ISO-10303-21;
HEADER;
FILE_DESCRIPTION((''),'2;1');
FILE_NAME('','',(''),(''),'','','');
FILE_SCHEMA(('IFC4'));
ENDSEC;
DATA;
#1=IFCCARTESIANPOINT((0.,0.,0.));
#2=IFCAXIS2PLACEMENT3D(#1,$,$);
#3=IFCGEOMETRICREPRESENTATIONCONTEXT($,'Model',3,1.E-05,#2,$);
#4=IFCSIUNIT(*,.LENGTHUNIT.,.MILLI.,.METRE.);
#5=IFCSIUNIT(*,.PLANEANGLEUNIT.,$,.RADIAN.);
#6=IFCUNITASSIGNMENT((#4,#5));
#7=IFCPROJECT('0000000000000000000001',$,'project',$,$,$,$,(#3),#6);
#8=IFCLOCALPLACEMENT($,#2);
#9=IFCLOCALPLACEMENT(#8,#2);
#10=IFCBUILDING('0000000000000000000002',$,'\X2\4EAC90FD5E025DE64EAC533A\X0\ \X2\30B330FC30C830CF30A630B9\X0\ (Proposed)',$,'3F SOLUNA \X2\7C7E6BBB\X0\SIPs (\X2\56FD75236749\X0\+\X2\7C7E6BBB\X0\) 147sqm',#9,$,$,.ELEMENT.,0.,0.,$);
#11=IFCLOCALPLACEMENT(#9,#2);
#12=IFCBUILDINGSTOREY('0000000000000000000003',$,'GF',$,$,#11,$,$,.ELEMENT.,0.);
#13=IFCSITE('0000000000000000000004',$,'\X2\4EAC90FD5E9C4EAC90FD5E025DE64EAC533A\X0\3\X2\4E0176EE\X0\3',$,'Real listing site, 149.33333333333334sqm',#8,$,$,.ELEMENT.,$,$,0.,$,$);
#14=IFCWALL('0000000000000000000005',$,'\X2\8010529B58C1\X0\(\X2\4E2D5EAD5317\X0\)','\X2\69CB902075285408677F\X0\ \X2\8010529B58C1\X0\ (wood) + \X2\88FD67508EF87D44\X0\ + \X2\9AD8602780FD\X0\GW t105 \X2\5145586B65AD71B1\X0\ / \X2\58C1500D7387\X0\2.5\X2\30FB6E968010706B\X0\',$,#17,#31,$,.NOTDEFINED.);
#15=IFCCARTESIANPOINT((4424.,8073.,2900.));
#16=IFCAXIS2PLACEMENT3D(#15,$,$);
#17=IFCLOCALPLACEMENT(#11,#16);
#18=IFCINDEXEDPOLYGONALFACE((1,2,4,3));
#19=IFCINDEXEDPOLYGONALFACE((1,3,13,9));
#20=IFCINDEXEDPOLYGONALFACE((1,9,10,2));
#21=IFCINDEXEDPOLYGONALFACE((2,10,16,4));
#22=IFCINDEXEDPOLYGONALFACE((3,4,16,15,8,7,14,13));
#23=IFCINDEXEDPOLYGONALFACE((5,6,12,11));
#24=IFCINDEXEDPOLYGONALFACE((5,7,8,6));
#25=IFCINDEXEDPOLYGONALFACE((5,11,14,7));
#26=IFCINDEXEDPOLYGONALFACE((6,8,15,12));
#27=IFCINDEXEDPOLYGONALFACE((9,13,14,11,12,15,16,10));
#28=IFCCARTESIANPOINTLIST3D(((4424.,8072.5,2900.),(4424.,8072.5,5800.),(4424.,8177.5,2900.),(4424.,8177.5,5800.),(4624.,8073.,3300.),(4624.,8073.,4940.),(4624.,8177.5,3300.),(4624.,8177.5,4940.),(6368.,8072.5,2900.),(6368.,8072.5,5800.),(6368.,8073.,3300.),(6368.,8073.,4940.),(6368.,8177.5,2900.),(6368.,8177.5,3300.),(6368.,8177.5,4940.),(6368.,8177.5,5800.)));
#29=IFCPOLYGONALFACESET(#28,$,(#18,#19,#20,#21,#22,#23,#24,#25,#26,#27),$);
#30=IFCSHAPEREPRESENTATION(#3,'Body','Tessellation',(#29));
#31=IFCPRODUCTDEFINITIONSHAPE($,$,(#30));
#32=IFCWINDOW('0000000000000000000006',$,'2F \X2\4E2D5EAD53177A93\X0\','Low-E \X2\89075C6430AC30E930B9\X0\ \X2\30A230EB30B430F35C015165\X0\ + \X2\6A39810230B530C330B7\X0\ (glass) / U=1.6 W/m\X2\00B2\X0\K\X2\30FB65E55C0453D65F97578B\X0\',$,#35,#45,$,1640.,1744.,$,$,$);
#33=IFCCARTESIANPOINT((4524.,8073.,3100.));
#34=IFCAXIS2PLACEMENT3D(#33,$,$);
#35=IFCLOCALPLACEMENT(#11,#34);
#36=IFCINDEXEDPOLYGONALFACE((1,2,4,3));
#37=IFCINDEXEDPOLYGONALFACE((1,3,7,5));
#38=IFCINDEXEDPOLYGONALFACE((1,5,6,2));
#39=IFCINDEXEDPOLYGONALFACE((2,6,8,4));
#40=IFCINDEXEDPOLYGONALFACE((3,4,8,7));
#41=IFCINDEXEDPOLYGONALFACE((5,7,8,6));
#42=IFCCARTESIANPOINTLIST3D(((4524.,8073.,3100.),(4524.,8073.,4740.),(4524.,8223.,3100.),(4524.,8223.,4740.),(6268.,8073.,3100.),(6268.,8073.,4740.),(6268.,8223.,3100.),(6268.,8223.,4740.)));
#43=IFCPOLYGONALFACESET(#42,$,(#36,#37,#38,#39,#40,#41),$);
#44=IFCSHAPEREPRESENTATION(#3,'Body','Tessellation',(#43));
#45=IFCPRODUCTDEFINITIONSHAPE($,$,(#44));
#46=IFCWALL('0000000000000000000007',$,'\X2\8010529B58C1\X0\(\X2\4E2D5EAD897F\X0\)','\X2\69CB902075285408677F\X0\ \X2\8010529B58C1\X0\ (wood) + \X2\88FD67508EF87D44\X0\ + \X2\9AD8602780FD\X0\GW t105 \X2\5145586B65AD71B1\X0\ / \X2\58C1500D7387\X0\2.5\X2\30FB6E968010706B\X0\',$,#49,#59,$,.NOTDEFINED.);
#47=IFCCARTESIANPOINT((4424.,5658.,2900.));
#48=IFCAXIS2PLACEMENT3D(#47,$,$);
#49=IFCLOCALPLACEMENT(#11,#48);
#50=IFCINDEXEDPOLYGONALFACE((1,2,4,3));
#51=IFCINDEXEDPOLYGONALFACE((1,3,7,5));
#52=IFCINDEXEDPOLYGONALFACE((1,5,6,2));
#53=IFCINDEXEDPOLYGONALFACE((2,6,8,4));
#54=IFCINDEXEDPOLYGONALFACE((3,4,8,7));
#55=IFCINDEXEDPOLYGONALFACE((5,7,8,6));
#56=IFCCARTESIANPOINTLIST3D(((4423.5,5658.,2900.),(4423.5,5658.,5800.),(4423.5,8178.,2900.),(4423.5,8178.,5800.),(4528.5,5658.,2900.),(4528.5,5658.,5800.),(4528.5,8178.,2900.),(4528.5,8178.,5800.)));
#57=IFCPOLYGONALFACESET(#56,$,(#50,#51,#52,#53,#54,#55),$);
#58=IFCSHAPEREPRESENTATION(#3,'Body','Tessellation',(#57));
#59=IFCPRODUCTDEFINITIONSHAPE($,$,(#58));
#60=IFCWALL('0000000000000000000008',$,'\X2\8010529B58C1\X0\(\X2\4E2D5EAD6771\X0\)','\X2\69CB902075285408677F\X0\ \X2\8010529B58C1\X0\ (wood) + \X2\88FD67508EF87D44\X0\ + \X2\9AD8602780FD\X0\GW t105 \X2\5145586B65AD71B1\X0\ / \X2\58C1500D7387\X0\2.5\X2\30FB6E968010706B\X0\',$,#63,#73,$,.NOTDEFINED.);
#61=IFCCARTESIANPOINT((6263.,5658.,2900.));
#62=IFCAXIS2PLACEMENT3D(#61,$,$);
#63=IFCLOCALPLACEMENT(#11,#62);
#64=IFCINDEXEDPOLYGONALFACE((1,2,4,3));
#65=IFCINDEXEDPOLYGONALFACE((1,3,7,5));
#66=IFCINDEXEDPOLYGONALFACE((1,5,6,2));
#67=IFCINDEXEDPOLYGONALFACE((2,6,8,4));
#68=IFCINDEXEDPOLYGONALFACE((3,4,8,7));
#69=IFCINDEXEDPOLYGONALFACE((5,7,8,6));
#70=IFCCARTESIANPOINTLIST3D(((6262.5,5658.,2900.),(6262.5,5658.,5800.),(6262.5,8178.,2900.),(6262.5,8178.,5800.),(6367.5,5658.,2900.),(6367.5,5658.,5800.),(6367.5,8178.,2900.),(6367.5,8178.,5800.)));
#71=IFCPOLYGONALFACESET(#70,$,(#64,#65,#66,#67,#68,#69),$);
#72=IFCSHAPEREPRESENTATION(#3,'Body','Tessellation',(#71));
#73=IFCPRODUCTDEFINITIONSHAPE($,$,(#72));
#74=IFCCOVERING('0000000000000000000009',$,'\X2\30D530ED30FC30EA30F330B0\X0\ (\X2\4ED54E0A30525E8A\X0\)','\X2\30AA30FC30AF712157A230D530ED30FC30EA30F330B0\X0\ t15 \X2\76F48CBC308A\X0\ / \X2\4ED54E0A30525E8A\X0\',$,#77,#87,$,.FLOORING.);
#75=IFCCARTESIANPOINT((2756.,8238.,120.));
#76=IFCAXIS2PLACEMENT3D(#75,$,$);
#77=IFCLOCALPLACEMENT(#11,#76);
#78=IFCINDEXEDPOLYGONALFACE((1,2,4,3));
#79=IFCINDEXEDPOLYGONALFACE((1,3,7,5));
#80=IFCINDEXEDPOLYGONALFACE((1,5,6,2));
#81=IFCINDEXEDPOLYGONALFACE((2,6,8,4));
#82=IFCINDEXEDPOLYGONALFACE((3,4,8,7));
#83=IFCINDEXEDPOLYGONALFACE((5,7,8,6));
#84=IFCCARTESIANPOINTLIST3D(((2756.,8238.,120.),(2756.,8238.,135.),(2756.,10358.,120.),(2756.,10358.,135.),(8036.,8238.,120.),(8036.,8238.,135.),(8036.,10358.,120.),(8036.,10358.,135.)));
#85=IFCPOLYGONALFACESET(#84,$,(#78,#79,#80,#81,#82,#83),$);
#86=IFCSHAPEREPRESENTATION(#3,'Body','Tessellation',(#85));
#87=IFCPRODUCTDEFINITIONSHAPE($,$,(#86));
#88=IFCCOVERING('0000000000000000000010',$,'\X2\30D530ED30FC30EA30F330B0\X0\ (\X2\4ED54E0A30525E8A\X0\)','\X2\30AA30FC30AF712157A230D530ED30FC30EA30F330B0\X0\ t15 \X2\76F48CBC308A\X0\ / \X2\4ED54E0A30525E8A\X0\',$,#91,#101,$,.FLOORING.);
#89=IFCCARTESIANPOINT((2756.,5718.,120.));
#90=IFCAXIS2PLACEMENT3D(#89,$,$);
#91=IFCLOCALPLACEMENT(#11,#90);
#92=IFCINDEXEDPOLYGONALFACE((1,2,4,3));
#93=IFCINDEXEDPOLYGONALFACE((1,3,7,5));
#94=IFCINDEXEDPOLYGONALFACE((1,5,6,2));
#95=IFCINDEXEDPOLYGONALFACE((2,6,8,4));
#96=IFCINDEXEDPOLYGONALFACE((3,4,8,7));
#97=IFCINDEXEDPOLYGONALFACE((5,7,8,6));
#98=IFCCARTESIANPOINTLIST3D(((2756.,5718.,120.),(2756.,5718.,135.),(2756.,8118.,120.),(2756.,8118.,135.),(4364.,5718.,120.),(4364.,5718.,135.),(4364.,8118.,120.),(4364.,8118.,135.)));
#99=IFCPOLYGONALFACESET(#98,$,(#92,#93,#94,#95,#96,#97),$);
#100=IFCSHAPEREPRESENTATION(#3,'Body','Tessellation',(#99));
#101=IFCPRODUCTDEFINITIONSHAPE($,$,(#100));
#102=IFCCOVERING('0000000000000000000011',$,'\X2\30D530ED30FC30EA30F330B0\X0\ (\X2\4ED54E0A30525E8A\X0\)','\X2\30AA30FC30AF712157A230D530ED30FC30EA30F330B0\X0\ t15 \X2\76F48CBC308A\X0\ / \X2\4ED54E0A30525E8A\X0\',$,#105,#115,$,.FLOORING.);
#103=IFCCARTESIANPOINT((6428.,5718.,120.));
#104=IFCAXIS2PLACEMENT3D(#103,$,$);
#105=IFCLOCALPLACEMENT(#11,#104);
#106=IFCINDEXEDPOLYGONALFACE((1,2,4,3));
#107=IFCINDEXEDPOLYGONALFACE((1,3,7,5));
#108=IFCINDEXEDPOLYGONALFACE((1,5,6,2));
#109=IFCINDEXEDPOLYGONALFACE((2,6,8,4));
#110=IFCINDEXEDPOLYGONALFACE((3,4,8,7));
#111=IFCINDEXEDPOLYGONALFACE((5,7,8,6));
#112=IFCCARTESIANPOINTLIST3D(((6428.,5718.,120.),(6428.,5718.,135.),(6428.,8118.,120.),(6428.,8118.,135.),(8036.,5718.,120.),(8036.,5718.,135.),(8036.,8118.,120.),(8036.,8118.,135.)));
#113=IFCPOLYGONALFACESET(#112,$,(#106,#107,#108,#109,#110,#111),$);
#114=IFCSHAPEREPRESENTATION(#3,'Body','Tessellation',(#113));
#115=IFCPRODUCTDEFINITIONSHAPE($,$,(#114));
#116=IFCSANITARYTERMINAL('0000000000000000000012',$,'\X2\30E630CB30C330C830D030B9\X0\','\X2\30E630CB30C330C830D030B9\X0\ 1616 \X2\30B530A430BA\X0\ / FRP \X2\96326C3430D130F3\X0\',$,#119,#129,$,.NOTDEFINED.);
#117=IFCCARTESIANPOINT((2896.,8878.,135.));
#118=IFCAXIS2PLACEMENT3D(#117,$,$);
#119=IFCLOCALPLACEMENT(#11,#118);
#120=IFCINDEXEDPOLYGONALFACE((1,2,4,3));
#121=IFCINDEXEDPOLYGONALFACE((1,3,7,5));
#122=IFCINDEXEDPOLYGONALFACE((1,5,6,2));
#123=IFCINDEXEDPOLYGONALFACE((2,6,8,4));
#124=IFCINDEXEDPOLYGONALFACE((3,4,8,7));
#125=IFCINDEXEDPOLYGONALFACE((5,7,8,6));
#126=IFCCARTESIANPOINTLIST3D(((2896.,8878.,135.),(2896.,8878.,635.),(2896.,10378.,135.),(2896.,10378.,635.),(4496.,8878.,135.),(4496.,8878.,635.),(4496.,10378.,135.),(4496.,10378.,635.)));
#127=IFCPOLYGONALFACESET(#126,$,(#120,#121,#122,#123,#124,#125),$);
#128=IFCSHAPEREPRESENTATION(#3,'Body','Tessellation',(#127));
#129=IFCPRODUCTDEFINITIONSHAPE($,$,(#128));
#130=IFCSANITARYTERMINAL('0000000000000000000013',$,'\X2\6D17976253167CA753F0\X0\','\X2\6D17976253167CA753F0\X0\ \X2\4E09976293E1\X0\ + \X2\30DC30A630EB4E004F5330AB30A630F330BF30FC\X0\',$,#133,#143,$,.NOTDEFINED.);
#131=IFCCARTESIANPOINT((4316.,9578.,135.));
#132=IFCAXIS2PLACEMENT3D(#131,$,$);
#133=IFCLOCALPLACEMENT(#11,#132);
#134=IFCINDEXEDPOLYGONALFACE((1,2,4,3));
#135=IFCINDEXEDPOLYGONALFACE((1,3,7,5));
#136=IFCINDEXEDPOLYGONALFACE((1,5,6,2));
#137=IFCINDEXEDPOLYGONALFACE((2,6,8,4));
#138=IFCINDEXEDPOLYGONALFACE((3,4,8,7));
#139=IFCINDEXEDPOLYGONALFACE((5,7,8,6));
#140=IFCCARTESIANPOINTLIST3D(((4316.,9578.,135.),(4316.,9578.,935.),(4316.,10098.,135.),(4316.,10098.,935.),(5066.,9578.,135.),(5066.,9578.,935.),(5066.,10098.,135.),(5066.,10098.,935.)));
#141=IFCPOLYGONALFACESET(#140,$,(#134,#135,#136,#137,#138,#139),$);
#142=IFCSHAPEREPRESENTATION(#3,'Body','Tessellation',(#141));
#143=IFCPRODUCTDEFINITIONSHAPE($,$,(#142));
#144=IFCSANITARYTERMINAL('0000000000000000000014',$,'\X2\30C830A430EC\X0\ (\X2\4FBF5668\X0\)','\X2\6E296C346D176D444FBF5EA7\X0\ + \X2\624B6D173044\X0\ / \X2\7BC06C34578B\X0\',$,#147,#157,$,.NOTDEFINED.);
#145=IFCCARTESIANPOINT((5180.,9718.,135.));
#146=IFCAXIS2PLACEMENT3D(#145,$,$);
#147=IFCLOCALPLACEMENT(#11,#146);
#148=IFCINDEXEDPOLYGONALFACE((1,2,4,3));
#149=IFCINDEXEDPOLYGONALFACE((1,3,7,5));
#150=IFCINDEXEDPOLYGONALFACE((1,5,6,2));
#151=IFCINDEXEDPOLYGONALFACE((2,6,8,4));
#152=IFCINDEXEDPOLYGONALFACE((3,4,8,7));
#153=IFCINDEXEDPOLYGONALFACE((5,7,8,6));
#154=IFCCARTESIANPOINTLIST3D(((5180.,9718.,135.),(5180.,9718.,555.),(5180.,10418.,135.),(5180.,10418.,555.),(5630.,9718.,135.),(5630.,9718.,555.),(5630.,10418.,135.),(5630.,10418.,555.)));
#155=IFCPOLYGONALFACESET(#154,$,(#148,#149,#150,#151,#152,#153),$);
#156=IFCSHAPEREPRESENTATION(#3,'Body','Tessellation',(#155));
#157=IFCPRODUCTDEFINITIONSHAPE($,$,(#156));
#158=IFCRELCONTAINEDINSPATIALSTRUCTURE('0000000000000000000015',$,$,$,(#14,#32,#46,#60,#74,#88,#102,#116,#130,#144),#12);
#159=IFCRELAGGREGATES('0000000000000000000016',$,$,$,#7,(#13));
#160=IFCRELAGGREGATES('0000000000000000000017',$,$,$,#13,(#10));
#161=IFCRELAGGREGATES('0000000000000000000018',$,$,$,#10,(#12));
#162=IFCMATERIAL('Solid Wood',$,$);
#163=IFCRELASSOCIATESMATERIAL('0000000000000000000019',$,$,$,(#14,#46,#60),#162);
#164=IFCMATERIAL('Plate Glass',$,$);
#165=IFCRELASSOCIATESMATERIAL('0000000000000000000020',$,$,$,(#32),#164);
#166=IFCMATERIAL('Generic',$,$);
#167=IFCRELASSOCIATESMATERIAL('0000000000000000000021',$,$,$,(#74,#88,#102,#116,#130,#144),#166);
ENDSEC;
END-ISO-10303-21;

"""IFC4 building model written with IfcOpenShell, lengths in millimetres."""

from ifc_helpers import new_model, si_unit, frame, frame_2d, origin, place, context, project, spatial, rectangle, extrude, material, element, fill, save


model = new_model("IFC4")

# Units and contexts
model_context = context("Model", 3, precision=1e-05, world=origin())
ifc_project = project(units=[si_unit("LENGTHUNIT", "METRE", prefix="MILLI"), si_unit("PLANEANGLEUNIT", "RADIAN")], contexts=[model_context])

# Site, building, storey
site_placement = place(None, origin())
site = spatial("IfcSite", under=ifc_project, at=site_placement, Name="京都府京都市左京区3丁目3", ObjectType="Real listing site, 149.33333333333334sqm", CompositionType="ELEMENT", RefElevation=0.0)
building_placement = place(site_placement, origin())
building = spatial("IfcBuilding", under=site, at=building_placement, Name="京都市左京区 コートハウス (Proposed)", ObjectType="3F SOLUNA 籾殻SIPs (国産杉+籾殻) 147sqm", CompositionType="ELEMENT", ElevationOfRefHeight=0.0, ElevationOfTerrain=0.0)
storey_placement = place(building_placement, origin())
storey = spatial("IfcBuildingStorey", under=building, at=storey_placement, Name="GF", CompositionType="ELEMENT", Elevation=0.0)

# Shared definitions
ifc_material_1 = material(Name="Solid Wood")

# Shared definitions
ifc_material_2 = material(Name="Plate Glass")

# Wall, opening, window
wall_1_placement = place(storey_placement, frame((4424.0, 8073.0, 2900.0)))
wall_1 = element("IfcWall", 1, at=wall_1_placement, inside=storey, material=ifc_material_1, Name="耐力壁(中庭北)", Description="構造用合板 耐力壁 (wood) + 製材軸組 + 高性能GW t105 充填断熱 / 壁倍率2.5・準耐火", PredefinedType="NOTDEFINED", context=model_context, shape_type="SweptSolid", body=[
    extrude(rectangle(XDim=1944.0, YDim=105.0, at=frame_2d((972.0, 52.0))), frame((4424.0, 8073.0, 2900.0)), (0.0, 0.0, 1.0), 2900.0),
])
opening_1_placement = place(storey_placement, frame((4524.0, 8073.0, 3100.0)))
opening_1 = element("IfcOpeningElement", 2, at=opening_1_placement, cuts=wall_1, PredefinedType="NOTDEFINED", context=model_context, shape_type="SweptSolid", body=[
    extrude(rectangle(XDim=1744.0, YDim=150.0, at=frame_2d((872.0, 75.0))), frame((4524.0, 8073.0, 3100.0)), (0.0, 0.0, 1.0), 1640.0),
])
window_1_placement = place(storey_placement, frame((4524.0, 8073.0, 3100.0)))
window_1 = element("IfcWindow", 3, at=window_1_placement, inside=storey, material=ifc_material_2, Name="2F 中庭北窓", Description="Low-E 複層ガラス アルゴン封入 + 樹脂サッシ (glass) / U=1.6 W/m²K・日射取得型", OverallHeight=1640.0, OverallWidth=1744.0, context=model_context, shape_type="SweptSolid", body=[
    extrude(rectangle(XDim=1744.0, YDim=150.0, at=frame_2d((872.0, 75.0))), frame((4524.0, 8073.0, 3100.0)), (0.0, 0.0, 1.0), 1640.0),
])
fill(opening_1, window_1)

# Walls
wall_2_placement = place(storey_placement, frame((4424.0, 5658.0, 2900.0)))
element("IfcWall", 4, at=wall_2_placement, inside=storey, material=ifc_material_1, Name="耐力壁(中庭西)", Description="構造用合板 耐力壁 (wood) + 製材軸組 + 高性能GW t105 充填断熱 / 壁倍率2.5・準耐火", PredefinedType="NOTDEFINED", context=model_context, shape_type="SweptSolid", body=[
    extrude(rectangle(XDim=105.0, YDim=2520.0, at=frame_2d((52.0, 1260.0))), frame((4424.0, 5658.0, 2900.0)), (0.0, 0.0, 1.0), 2900.0),
])
wall_3_placement = place(storey_placement, frame((6263.0, 5658.0, 2900.0)))
element("IfcWall", 5, at=wall_3_placement, inside=storey, material=ifc_material_1, Name="耐力壁(中庭東)", Description="構造用合板 耐力壁 (wood) + 製材軸組 + 高性能GW t105 充填断熱 / 壁倍率2.5・準耐火", PredefinedType="NOTDEFINED", context=model_context, shape_type="SweptSolid", body=[
    extrude(rectangle(XDim=105.0, YDim=2520.0, at=frame_2d((52.0, 1260.0))), frame((6263.0, 5658.0, 2900.0)), (0.0, 0.0, 1.0), 2900.0),
])

# Coverings
ifc_material_3 = material(Name="Generic")
covering_1_placement = place(storey_placement, frame((2756.0, 8238.0, 120.0)))
element("IfcCovering", 6, at=covering_1_placement, inside=storey, material=ifc_material_3, Name="フローリング (仕上げ床)", Description="オーク無垢フローリング t15 直貼り / 仕上げ床", PredefinedType="FLOORING", context=model_context, shape_type="SweptSolid", body=[
    extrude(rectangle(XDim=5280.0, YDim=2120.0, at=frame_2d((2640.0, 1060.0))), frame((2756.0, 8238.0, 120.0)), (0.0, 0.0, 1.0), 15.0),
])
covering_2_placement = place(storey_placement, frame((2756.0, 5718.0, 120.0)))
element("IfcCovering", 7, at=covering_2_placement, inside=storey, material=ifc_material_3, Name="フローリング (仕上げ床)", Description="オーク無垢フローリング t15 直貼り / 仕上げ床", PredefinedType="FLOORING", context=model_context, shape_type="SweptSolid", body=[
    extrude(rectangle(XDim=1608.0, YDim=2400.0, at=frame_2d((804.0, 1200.0))), frame((2756.0, 5718.0, 120.0)), (0.0, 0.0, 1.0), 15.0),
])
covering_3_placement = place(storey_placement, frame((6428.0, 5718.0, 120.0)))
element("IfcCovering", 8, at=covering_3_placement, inside=storey, material=ifc_material_3, Name="フローリング (仕上げ床)", Description="オーク無垢フローリング t15 直貼り / 仕上げ床", PredefinedType="FLOORING", context=model_context, shape_type="SweptSolid", body=[
    extrude(rectangle(XDim=1608.0, YDim=2400.0, at=frame_2d((804.0, 1200.0))), frame((6428.0, 5718.0, 120.0)), (0.0, 0.0, 1.0), 15.0),
])

# Sanitary terminals
sanitary_terminal_1_placement = place(storey_placement, frame((2896.0, 8878.0, 135.0)))
element("IfcSanitaryTerminal", 9, at=sanitary_terminal_1_placement, inside=storey, material=ifc_material_3, Name="ユニットバス", Description="ユニットバス 1616 サイズ / FRP 防水パン", PredefinedType="NOTDEFINED", context=model_context, shape_type="SweptSolid", body=[
    extrude(rectangle(XDim=1600.0, YDim=1500.0, at=frame_2d((800.0, 750.0))), frame((2896.0, 8878.0, 135.0)), (0.0, 0.0, 1.0), 500.0),
])
sanitary_terminal_2_placement = place(storey_placement, frame((4316.0, 9578.0, 135.0)))
element("IfcSanitaryTerminal", 10, at=sanitary_terminal_2_placement, inside=storey, material=ifc_material_3, Name="洗面化粧台", Description="洗面化粧台 三面鏡 + ボウル一体カウンター", PredefinedType="NOTDEFINED", context=model_context, shape_type="SweptSolid", body=[
    extrude(rectangle(XDim=750.0, YDim=520.0, at=frame_2d((375.0, 260.0))), frame((4316.0, 9578.0, 135.0)), (0.0, 0.0, 1.0), 800.0),
])
sanitary_terminal_3_placement = place(storey_placement, frame((5180.0, 9718.0, 135.0)))
element("IfcSanitaryTerminal", 11, at=sanitary_terminal_3_placement, inside=storey, material=ifc_material_3, Name="トイレ (便器)", Description="温水洗浄便座 + 手洗い / 節水型", PredefinedType="NOTDEFINED", context=model_context, shape_type="SweptSolid", body=[
    extrude(rectangle(XDim=450.0, YDim=700.0, at=frame_2d((225.0, 350.0))), frame((5180.0, 9718.0, 135.0)), (0.0, 0.0, 1.0), 420.0),
])

save(model, "model.ifc")
